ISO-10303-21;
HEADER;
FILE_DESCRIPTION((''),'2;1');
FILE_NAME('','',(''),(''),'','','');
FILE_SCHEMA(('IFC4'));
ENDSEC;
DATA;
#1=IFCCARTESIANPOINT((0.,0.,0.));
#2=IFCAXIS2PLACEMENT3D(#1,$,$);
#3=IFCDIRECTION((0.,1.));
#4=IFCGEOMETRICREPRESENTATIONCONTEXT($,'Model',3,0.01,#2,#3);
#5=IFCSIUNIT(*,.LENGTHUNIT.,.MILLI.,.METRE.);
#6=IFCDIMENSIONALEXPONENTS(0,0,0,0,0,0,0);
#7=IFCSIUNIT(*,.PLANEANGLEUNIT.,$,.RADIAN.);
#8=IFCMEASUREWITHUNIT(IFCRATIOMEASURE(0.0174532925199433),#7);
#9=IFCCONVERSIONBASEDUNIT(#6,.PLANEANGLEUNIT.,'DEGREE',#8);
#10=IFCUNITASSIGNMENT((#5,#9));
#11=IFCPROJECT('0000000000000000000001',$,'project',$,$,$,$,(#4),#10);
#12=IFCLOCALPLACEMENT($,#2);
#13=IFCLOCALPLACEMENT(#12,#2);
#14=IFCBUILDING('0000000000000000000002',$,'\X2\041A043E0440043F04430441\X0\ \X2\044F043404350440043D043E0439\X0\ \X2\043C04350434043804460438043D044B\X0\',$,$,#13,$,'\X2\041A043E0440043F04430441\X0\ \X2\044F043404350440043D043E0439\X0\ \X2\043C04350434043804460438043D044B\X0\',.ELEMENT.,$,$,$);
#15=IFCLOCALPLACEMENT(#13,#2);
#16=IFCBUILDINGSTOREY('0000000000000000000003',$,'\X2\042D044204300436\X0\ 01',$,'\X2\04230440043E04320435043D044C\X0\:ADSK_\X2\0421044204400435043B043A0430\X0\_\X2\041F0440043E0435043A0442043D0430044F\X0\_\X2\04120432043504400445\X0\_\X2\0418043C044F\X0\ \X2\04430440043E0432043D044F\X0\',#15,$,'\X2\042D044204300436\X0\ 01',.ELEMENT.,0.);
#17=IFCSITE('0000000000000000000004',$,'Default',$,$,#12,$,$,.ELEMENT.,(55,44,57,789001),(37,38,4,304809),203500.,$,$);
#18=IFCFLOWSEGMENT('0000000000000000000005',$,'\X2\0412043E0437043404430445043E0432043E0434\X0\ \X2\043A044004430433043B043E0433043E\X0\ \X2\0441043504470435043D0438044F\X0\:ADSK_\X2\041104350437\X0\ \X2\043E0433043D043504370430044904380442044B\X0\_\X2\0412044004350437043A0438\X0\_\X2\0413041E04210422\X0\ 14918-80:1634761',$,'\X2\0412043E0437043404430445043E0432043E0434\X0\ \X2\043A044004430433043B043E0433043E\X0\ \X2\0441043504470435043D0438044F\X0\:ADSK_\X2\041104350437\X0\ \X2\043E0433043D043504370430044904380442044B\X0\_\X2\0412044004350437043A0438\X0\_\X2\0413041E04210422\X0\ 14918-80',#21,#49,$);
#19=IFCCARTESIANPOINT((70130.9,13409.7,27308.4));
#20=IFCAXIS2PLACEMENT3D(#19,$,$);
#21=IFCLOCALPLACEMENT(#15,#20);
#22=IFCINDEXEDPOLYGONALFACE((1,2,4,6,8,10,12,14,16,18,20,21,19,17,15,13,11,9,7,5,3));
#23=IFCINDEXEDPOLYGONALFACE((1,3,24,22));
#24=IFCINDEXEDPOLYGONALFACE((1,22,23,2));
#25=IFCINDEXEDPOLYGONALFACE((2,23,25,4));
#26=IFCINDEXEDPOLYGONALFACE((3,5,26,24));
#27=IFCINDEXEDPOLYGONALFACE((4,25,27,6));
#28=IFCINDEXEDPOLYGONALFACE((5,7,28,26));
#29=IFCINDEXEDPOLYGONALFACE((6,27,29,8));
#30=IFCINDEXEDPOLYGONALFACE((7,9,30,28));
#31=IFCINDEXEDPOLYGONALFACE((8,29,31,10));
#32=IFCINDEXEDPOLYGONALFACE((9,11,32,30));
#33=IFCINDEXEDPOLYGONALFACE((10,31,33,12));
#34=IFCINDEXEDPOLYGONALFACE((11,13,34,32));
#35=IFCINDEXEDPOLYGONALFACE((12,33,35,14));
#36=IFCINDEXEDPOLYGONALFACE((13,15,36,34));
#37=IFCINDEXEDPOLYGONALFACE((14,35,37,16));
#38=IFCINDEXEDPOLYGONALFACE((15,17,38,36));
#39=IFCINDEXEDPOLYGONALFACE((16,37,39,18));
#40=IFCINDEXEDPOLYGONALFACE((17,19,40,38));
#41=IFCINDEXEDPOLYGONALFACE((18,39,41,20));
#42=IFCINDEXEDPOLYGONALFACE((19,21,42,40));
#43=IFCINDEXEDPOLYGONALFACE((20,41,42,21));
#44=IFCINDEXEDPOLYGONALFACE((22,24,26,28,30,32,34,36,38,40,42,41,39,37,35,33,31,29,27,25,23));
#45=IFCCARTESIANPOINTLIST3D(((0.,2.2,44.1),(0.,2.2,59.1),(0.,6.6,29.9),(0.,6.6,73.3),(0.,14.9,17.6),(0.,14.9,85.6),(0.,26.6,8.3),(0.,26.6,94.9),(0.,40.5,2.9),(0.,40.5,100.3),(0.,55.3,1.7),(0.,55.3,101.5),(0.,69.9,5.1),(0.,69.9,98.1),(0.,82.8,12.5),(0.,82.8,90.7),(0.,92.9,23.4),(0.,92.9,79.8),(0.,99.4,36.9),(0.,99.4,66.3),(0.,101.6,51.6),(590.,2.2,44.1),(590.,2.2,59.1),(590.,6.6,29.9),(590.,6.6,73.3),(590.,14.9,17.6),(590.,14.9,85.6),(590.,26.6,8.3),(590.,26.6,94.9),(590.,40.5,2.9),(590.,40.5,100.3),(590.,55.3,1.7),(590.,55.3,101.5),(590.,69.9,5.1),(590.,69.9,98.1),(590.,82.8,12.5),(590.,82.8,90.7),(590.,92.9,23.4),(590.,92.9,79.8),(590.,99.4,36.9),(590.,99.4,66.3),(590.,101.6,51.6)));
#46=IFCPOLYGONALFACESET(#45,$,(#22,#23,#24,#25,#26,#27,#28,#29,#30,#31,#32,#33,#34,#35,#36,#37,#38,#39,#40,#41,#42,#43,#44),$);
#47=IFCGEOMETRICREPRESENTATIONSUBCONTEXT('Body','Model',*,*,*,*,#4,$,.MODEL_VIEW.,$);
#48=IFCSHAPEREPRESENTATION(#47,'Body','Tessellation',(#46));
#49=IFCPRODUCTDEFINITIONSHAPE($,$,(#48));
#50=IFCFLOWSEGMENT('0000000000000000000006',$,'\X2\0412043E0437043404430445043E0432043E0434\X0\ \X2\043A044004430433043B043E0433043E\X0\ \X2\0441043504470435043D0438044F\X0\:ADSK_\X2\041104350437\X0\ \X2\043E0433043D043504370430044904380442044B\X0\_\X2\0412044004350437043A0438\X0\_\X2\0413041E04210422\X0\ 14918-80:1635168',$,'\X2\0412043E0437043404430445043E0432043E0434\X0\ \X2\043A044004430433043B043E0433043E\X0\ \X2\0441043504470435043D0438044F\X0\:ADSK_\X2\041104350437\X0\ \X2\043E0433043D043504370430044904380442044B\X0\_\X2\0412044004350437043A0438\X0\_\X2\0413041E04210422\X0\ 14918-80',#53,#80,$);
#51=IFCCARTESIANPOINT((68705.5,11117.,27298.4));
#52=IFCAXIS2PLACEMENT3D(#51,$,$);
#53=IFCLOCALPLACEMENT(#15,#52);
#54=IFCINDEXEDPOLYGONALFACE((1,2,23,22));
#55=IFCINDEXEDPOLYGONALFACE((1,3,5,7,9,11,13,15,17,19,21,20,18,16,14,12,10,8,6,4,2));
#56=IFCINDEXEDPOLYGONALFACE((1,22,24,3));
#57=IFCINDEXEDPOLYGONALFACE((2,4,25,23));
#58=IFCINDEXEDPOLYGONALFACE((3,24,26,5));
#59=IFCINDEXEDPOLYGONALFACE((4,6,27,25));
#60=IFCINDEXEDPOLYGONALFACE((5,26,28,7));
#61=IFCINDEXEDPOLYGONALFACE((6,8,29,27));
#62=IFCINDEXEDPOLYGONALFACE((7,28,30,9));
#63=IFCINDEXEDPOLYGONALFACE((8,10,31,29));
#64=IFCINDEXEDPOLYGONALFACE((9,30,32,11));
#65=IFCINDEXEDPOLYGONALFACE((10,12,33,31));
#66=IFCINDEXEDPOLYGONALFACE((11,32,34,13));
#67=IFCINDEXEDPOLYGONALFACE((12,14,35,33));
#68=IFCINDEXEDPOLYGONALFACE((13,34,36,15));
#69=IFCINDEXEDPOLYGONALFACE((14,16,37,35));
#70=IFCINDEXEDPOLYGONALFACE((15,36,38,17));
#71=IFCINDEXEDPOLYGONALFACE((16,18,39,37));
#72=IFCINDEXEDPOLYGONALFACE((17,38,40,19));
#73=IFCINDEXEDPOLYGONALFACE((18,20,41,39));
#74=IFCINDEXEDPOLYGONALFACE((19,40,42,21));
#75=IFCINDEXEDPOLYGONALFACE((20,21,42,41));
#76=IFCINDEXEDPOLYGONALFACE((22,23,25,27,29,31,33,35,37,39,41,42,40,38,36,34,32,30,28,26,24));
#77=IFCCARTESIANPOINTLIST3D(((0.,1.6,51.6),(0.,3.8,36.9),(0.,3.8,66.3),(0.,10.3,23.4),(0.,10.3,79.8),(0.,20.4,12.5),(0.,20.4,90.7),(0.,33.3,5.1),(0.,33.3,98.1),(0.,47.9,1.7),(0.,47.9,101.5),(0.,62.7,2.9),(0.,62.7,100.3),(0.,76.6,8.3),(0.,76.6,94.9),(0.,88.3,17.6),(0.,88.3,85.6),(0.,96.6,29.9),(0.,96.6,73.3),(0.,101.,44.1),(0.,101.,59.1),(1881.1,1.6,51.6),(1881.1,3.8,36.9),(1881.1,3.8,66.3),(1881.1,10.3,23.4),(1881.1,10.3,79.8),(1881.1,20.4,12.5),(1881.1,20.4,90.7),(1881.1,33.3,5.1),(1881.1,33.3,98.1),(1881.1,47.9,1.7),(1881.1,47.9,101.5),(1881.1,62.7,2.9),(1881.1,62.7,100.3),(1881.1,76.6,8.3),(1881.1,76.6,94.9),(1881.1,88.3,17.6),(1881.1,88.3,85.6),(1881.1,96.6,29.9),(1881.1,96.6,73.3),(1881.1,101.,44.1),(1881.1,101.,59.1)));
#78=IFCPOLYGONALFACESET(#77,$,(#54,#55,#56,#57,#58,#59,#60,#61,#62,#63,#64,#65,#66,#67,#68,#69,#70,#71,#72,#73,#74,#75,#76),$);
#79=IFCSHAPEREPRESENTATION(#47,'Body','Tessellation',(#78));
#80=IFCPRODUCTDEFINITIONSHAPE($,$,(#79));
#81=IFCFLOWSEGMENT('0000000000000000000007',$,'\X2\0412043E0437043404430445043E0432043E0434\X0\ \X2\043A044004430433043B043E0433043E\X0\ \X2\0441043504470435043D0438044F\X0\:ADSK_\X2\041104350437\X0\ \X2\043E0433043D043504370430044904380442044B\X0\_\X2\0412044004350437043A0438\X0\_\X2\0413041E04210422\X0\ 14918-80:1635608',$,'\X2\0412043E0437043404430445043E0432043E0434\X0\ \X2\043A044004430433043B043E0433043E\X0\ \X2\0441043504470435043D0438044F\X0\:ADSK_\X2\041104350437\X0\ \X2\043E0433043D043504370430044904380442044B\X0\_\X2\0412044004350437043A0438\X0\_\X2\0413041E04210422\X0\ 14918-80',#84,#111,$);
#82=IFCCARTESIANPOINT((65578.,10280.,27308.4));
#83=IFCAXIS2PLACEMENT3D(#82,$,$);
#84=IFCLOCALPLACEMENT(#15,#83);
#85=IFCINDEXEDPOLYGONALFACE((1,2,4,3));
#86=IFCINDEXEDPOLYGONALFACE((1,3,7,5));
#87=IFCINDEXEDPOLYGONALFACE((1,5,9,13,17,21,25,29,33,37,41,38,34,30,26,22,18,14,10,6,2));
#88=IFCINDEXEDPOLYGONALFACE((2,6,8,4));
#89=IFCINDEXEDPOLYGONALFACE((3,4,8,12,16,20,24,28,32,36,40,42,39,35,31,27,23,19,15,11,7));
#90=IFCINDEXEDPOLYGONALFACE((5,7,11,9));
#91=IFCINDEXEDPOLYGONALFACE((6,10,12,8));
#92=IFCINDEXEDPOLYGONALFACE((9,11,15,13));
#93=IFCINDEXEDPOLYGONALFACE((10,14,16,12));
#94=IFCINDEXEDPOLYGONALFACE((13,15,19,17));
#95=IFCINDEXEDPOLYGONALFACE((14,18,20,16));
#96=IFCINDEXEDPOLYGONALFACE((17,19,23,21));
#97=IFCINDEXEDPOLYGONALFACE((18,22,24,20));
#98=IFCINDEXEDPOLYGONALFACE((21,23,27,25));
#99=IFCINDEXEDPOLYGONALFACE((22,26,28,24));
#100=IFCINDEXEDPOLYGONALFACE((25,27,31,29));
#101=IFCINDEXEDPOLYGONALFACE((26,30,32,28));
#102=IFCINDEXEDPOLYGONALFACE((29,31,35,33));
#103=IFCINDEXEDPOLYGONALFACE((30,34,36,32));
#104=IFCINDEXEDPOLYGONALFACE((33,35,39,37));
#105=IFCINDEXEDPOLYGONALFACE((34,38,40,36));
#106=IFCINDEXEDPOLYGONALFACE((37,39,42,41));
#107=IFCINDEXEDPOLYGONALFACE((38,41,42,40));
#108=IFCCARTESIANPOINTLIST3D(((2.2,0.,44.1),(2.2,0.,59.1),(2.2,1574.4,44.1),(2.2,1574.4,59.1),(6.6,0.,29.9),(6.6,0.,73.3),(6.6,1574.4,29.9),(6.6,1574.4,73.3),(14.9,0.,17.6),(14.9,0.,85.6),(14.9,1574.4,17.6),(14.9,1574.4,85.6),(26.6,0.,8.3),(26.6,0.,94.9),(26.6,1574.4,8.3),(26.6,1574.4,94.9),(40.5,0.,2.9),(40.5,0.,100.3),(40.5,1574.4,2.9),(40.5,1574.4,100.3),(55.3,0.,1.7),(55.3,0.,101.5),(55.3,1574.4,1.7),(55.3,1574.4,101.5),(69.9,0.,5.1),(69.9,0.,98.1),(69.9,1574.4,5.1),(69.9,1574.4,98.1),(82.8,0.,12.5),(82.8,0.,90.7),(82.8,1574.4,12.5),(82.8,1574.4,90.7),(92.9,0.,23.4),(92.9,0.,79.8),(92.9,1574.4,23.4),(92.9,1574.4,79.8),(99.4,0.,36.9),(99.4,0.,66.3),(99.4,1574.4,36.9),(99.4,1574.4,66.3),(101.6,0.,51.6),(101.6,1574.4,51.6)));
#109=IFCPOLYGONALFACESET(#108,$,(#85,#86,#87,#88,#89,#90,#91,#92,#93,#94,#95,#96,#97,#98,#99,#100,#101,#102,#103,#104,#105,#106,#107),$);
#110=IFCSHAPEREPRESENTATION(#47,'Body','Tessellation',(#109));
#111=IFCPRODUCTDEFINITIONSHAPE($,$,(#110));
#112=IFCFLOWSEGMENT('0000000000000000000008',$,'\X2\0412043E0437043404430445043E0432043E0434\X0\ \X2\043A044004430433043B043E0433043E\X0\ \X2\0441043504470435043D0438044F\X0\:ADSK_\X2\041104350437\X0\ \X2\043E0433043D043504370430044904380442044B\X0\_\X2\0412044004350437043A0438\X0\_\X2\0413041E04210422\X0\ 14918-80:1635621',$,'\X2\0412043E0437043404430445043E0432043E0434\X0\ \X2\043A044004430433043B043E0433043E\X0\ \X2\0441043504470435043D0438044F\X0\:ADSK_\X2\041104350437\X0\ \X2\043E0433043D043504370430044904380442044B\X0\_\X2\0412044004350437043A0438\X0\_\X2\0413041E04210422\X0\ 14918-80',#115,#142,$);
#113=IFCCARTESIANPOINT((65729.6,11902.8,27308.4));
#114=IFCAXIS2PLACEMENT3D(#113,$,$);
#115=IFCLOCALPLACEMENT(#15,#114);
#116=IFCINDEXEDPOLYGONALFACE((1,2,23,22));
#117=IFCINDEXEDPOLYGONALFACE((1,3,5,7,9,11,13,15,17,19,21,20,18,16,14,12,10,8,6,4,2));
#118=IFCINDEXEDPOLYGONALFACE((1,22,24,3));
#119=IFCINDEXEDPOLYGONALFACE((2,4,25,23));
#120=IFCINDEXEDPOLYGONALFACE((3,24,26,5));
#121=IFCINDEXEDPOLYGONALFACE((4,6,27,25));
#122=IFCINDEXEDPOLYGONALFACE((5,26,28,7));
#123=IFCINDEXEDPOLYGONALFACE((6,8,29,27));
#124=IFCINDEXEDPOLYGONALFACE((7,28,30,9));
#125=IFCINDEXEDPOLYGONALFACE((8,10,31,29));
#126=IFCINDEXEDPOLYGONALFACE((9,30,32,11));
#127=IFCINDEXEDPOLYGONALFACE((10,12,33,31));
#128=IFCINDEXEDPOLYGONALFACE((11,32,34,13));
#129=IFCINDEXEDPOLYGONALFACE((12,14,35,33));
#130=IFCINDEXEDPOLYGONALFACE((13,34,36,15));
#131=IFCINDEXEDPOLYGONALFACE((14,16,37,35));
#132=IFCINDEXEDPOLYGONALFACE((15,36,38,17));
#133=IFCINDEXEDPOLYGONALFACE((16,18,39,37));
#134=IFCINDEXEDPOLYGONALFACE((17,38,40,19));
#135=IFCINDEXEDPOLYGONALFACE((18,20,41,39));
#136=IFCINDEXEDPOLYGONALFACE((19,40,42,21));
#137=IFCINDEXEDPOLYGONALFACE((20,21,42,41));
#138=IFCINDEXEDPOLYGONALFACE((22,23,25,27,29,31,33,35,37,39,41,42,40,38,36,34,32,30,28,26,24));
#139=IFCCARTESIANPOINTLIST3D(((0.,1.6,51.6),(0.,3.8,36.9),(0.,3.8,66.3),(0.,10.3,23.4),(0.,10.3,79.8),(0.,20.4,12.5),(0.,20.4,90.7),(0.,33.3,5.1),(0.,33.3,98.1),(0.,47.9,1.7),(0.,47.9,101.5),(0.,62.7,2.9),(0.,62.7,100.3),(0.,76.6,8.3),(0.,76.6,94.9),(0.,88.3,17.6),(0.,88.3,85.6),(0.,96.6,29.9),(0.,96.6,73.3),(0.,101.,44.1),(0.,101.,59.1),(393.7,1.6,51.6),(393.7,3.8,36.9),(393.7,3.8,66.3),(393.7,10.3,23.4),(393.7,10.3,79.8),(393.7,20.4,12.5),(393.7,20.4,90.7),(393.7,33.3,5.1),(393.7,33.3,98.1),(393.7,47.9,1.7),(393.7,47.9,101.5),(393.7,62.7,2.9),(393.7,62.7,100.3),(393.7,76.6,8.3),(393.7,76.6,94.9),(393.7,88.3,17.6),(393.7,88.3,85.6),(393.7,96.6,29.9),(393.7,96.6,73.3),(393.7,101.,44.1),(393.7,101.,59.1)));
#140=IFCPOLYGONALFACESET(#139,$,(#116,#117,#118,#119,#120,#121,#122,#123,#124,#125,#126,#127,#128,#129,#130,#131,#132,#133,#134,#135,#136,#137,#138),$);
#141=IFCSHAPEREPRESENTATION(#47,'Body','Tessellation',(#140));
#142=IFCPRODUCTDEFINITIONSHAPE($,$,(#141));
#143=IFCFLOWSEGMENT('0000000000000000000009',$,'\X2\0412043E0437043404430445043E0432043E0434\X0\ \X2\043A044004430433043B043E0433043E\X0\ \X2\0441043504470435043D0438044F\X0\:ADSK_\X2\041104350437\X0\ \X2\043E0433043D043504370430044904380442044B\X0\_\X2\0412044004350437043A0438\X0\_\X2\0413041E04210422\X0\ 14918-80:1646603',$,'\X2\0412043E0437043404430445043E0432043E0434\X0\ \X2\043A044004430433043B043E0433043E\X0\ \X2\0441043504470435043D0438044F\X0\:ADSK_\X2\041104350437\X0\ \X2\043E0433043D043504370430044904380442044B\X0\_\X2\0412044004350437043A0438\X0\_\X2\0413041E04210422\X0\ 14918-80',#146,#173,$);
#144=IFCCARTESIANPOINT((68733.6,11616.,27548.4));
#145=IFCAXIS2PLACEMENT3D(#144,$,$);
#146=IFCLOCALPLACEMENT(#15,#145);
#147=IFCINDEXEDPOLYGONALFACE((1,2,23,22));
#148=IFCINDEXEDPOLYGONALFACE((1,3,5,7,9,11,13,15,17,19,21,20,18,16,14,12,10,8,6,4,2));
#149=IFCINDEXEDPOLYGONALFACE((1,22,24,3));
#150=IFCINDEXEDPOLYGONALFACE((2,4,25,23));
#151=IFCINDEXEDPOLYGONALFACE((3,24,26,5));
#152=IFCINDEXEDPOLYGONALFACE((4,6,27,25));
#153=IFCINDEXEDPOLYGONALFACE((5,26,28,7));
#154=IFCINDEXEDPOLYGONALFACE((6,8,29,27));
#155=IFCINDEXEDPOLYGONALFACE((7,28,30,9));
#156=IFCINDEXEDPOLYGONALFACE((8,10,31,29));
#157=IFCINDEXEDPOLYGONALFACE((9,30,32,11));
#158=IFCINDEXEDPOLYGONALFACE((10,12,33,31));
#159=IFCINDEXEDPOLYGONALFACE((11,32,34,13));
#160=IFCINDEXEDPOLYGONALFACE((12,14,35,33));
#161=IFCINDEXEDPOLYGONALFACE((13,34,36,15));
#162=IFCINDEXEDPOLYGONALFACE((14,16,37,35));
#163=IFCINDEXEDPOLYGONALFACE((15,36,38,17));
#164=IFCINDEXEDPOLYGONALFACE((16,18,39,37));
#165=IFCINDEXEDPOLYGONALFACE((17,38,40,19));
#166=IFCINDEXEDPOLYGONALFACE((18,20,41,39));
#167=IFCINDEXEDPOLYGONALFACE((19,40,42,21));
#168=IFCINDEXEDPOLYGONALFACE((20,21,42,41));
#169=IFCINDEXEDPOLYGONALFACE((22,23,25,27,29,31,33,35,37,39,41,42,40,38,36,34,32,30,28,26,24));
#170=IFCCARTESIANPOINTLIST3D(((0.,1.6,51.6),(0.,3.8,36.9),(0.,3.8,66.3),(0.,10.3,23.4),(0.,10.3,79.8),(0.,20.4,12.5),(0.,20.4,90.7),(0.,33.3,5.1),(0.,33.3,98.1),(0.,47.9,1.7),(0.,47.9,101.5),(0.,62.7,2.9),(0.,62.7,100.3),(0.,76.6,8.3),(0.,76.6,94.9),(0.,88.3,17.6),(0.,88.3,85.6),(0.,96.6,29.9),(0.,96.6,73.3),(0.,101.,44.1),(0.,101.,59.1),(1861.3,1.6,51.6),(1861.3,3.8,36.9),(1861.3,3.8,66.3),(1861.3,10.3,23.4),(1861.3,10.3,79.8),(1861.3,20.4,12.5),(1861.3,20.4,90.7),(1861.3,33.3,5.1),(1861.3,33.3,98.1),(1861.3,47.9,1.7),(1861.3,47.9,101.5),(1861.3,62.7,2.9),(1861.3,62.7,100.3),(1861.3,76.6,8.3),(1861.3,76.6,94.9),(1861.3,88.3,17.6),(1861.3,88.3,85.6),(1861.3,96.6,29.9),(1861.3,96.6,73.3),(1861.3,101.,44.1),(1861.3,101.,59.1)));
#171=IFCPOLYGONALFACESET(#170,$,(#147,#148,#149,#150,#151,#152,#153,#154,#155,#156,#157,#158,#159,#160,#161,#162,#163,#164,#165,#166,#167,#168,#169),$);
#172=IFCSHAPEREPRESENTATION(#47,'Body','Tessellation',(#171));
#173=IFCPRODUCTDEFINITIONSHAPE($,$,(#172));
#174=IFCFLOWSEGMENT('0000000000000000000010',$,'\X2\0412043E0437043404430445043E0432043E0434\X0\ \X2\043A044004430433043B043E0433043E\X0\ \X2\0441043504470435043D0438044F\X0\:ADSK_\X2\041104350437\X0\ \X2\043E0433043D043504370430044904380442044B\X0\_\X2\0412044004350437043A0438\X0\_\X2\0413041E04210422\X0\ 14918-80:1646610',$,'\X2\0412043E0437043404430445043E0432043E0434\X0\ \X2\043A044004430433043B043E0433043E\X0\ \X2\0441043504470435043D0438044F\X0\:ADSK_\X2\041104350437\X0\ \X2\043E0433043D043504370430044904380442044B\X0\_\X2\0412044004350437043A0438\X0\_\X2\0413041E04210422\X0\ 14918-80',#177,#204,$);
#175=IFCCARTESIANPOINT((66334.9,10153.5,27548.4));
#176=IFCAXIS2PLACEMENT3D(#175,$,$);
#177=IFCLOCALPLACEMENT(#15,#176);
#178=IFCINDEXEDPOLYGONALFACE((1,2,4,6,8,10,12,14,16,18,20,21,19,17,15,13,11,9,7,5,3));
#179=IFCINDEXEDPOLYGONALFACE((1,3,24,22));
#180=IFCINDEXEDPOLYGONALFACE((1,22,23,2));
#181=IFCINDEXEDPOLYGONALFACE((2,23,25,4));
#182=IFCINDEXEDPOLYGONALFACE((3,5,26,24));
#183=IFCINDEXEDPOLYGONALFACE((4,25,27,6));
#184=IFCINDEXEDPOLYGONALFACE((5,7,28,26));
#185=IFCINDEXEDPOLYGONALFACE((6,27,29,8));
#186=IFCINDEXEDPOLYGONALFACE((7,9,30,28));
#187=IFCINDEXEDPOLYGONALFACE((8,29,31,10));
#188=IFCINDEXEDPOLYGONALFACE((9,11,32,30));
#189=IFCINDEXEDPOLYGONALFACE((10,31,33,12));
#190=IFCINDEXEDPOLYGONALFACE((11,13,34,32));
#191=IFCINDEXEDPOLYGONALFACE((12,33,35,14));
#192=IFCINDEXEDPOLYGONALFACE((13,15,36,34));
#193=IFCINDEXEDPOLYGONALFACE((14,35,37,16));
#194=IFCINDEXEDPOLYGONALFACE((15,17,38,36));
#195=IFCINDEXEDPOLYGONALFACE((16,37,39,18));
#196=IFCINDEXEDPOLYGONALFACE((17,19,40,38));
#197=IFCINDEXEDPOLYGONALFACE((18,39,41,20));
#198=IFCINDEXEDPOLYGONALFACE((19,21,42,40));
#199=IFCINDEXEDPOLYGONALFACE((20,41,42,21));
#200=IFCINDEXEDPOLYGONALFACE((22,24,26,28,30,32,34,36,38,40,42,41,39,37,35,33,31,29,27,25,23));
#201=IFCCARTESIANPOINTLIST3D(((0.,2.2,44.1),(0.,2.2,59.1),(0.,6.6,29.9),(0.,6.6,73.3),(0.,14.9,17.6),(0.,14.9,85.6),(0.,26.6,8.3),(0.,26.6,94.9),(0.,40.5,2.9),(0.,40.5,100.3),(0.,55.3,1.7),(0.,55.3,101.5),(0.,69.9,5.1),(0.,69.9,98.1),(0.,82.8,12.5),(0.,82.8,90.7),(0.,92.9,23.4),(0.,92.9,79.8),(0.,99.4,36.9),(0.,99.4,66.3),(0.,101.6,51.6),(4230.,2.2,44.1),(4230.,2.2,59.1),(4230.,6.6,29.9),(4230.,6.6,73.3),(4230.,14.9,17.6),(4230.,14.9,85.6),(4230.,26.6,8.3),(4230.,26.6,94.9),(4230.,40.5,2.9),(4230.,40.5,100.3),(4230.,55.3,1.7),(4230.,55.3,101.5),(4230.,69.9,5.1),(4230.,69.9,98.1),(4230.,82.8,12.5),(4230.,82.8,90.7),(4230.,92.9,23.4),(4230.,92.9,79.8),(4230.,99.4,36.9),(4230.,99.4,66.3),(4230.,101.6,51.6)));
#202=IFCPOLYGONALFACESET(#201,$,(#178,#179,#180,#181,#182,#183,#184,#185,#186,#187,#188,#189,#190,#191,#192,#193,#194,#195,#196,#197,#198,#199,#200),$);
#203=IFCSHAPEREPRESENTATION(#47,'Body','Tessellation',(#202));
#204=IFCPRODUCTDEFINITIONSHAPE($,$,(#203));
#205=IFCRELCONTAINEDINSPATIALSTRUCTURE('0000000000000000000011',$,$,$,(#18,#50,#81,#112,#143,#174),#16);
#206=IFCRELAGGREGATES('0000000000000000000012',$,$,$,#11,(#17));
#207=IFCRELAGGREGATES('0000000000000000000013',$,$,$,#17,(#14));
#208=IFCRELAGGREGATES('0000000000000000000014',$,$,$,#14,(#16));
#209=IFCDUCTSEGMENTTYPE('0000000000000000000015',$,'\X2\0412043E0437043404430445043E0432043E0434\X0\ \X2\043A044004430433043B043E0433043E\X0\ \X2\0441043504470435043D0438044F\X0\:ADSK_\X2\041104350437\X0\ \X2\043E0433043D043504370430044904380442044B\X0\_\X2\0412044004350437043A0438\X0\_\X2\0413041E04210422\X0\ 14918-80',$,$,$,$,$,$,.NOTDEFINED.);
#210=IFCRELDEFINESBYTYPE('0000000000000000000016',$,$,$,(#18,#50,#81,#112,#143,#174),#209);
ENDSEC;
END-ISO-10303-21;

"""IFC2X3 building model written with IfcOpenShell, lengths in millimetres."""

from ifc_helpers import new_model, entity, si_unit, converted_unit, direction, frame, origin, origin_2d_with_axis, place, context, subcontext, project, spatial, circle, extrude, type_object, element, save


model = new_model("IFC2X3")

# Units and contexts
model_context = context("Model", 3, precision=0.01, world=origin(), true_north=direction((0.0, 1.0)))
body_context = subcontext(model_context, "Body", "Model", "MODEL_VIEW")
ifc_project = project(units=[si_unit("LENGTHUNIT", "METRE", prefix="MILLI"), converted_unit("PLANEANGLEUNIT", "DEGREE", entity("IfcRatioMeasure", 0.0174532925199433), si_unit("PLANEANGLEUNIT", "RADIAN"), dimensions=[0, 0, 0, 0, 0, 0, 0])], contexts=[model_context])

# Site, building, storey
site_placement = place(None, origin())
site = spatial("IfcSite", under=ifc_project, at=site_placement, Name="Default", CompositionType="ELEMENT", RefLatitude=(55, 44, 57, 789001), RefLongitude=(37, 38, 4, 304809), RefElevation=203500.0)
building_placement = place(site_placement, origin())
building = spatial("IfcBuilding", under=site, at=building_placement, Name="Корпус ядерной медицины", LongName="Корпус ядерной медицины", CompositionType="ELEMENT")
storey_placement = place(building_placement, origin())
storey = spatial("IfcBuildingStorey", under=building, at=storey_placement, Name="Этаж 01", ObjectType="Уровень:ADSK_Стрелка_Проектная_Вверх_Имя уровня", LongName="Этаж 01", CompositionType="ELEMENT", Elevation=0.0)

# Flow segments
duct_segment_type_1 = type_object("IfcDuctSegmentType", Name="Воздуховод круглого сечения:ADSK_Без огнезащиты_Врезки_ГОСТ 14918-80", PredefinedType="NOTDEFINED")
flow_segment_1_placement = place(storey_placement, frame((70130.9, 13409.7, 27308.4)))
element("IfcFlowSegment", 1, at=flow_segment_1_placement, inside=storey, type_object=duct_segment_type_1, Name="Воздуховод круглого сечения:ADSK_Без огнезащиты_Врезки_ГОСТ 14918-80:1634761", ObjectType="Воздуховод круглого сечения:ADSK_Без огнезащиты_Врезки_ГОСТ 14918-80", context=body_context, shape_type="SweptSolid", body=[
    extrude(circle(Radius=50.0, at=origin_2d_with_axis()), frame((0.0, 51.6, 51.6), z_axis=(1.0, 0.0, 0.0), x_axis=(0.0, 1.0, 0.0)), (0.0, 0.0, 1.0), 590.0),
])
flow_segment_2_placement = place(storey_placement, frame((68705.5, 11117.0, 27298.4)))
element("IfcFlowSegment", 2, at=flow_segment_2_placement, inside=storey, type_object=duct_segment_type_1, Name="Воздуховод круглого сечения:ADSK_Без огнезащиты_Врезки_ГОСТ 14918-80:1635168", ObjectType="Воздуховод круглого сечения:ADSK_Без огнезащиты_Врезки_ГОСТ 14918-80", context=body_context, shape_type="SweptSolid", body=[
    extrude(circle(Radius=50.0, at=origin_2d_with_axis()), frame((0.0, 51.6, 51.6), z_axis=(1.0, 0.0, 0.0), x_axis=(0.0, -1.0, 0.0)), (0.0, 0.0, 1.0), 1881.1),
])
flow_segment_3_placement = place(storey_placement, frame((65578.0, 10280.0, 27308.4)))
element("IfcFlowSegment", 3, at=flow_segment_3_placement, inside=storey, type_object=duct_segment_type_1, Name="Воздуховод круглого сечения:ADSK_Без огнезащиты_Врезки_ГОСТ 14918-80:1635608", ObjectType="Воздуховод круглого сечения:ADSK_Без огнезащиты_Врезки_ГОСТ 14918-80", context=body_context, shape_type="SweptSolid", body=[
    extrude(circle(Radius=50.0, at=origin_2d_with_axis()), frame((51.6, 0.0, 51.6), z_axis=(0.0, 1.0, 0.0), x_axis=(1.0, 0.0, 0.0)), (0.0, 0.0, 1.0), 1574.4),
])
flow_segment_4_placement = place(storey_placement, frame((65729.6, 11902.8, 27308.4)))
element("IfcFlowSegment", 4, at=flow_segment_4_placement, inside=storey, type_object=duct_segment_type_1, Name="Воздуховод круглого сечения:ADSK_Без огнезащиты_Врезки_ГОСТ 14918-80:1635621", ObjectType="Воздуховод круглого сечения:ADSK_Без огнезащиты_Врезки_ГОСТ 14918-80", context=body_context, shape_type="SweptSolid", body=[
    extrude(circle(Radius=50.0, at=origin_2d_with_axis()), frame((0.0, 51.6, 51.6), z_axis=(1.0, 0.0, 0.0), x_axis=(0.0, -1.0, 0.0)), (0.0, 0.0, 1.0), 393.7),
])
flow_segment_5_placement = place(storey_placement, frame((68733.6, 11616.0, 27548.4)))
element("IfcFlowSegment", 5, at=flow_segment_5_placement, inside=storey, type_object=duct_segment_type_1, Name="Воздуховод круглого сечения:ADSK_Без огнезащиты_Врезки_ГОСТ 14918-80:1646603", ObjectType="Воздуховод круглого сечения:ADSK_Без огнезащиты_Врезки_ГОСТ 14918-80", context=body_context, shape_type="SweptSolid", body=[
    extrude(circle(Radius=50.0, at=origin_2d_with_axis()), frame((0.0, 51.6, 51.6), z_axis=(1.0, 0.0, 0.0), x_axis=(0.0, -1.0, 0.0)), (0.0, 0.0, 1.0), 1861.3),
])
flow_segment_6_placement = place(storey_placement, frame((66334.9, 10153.5, 27548.4)))
element("IfcFlowSegment", 6, at=flow_segment_6_placement, inside=storey, type_object=duct_segment_type_1, Name="Воздуховод круглого сечения:ADSK_Без огнезащиты_Врезки_ГОСТ 14918-80:1646610", ObjectType="Воздуховод круглого сечения:ADSK_Без огнезащиты_Врезки_ГОСТ 14918-80", context=body_context, shape_type="SweptSolid", body=[
    extrude(circle(Radius=50.0, at=origin_2d_with_axis()), frame((0.0, 51.6, 51.6), z_axis=(1.0, 0.0, 0.0), x_axis=(0.0, 1.0, 0.0)), (0.0, 0.0, 1.0), 4230.0),
])

save(model, "model.ifc")
